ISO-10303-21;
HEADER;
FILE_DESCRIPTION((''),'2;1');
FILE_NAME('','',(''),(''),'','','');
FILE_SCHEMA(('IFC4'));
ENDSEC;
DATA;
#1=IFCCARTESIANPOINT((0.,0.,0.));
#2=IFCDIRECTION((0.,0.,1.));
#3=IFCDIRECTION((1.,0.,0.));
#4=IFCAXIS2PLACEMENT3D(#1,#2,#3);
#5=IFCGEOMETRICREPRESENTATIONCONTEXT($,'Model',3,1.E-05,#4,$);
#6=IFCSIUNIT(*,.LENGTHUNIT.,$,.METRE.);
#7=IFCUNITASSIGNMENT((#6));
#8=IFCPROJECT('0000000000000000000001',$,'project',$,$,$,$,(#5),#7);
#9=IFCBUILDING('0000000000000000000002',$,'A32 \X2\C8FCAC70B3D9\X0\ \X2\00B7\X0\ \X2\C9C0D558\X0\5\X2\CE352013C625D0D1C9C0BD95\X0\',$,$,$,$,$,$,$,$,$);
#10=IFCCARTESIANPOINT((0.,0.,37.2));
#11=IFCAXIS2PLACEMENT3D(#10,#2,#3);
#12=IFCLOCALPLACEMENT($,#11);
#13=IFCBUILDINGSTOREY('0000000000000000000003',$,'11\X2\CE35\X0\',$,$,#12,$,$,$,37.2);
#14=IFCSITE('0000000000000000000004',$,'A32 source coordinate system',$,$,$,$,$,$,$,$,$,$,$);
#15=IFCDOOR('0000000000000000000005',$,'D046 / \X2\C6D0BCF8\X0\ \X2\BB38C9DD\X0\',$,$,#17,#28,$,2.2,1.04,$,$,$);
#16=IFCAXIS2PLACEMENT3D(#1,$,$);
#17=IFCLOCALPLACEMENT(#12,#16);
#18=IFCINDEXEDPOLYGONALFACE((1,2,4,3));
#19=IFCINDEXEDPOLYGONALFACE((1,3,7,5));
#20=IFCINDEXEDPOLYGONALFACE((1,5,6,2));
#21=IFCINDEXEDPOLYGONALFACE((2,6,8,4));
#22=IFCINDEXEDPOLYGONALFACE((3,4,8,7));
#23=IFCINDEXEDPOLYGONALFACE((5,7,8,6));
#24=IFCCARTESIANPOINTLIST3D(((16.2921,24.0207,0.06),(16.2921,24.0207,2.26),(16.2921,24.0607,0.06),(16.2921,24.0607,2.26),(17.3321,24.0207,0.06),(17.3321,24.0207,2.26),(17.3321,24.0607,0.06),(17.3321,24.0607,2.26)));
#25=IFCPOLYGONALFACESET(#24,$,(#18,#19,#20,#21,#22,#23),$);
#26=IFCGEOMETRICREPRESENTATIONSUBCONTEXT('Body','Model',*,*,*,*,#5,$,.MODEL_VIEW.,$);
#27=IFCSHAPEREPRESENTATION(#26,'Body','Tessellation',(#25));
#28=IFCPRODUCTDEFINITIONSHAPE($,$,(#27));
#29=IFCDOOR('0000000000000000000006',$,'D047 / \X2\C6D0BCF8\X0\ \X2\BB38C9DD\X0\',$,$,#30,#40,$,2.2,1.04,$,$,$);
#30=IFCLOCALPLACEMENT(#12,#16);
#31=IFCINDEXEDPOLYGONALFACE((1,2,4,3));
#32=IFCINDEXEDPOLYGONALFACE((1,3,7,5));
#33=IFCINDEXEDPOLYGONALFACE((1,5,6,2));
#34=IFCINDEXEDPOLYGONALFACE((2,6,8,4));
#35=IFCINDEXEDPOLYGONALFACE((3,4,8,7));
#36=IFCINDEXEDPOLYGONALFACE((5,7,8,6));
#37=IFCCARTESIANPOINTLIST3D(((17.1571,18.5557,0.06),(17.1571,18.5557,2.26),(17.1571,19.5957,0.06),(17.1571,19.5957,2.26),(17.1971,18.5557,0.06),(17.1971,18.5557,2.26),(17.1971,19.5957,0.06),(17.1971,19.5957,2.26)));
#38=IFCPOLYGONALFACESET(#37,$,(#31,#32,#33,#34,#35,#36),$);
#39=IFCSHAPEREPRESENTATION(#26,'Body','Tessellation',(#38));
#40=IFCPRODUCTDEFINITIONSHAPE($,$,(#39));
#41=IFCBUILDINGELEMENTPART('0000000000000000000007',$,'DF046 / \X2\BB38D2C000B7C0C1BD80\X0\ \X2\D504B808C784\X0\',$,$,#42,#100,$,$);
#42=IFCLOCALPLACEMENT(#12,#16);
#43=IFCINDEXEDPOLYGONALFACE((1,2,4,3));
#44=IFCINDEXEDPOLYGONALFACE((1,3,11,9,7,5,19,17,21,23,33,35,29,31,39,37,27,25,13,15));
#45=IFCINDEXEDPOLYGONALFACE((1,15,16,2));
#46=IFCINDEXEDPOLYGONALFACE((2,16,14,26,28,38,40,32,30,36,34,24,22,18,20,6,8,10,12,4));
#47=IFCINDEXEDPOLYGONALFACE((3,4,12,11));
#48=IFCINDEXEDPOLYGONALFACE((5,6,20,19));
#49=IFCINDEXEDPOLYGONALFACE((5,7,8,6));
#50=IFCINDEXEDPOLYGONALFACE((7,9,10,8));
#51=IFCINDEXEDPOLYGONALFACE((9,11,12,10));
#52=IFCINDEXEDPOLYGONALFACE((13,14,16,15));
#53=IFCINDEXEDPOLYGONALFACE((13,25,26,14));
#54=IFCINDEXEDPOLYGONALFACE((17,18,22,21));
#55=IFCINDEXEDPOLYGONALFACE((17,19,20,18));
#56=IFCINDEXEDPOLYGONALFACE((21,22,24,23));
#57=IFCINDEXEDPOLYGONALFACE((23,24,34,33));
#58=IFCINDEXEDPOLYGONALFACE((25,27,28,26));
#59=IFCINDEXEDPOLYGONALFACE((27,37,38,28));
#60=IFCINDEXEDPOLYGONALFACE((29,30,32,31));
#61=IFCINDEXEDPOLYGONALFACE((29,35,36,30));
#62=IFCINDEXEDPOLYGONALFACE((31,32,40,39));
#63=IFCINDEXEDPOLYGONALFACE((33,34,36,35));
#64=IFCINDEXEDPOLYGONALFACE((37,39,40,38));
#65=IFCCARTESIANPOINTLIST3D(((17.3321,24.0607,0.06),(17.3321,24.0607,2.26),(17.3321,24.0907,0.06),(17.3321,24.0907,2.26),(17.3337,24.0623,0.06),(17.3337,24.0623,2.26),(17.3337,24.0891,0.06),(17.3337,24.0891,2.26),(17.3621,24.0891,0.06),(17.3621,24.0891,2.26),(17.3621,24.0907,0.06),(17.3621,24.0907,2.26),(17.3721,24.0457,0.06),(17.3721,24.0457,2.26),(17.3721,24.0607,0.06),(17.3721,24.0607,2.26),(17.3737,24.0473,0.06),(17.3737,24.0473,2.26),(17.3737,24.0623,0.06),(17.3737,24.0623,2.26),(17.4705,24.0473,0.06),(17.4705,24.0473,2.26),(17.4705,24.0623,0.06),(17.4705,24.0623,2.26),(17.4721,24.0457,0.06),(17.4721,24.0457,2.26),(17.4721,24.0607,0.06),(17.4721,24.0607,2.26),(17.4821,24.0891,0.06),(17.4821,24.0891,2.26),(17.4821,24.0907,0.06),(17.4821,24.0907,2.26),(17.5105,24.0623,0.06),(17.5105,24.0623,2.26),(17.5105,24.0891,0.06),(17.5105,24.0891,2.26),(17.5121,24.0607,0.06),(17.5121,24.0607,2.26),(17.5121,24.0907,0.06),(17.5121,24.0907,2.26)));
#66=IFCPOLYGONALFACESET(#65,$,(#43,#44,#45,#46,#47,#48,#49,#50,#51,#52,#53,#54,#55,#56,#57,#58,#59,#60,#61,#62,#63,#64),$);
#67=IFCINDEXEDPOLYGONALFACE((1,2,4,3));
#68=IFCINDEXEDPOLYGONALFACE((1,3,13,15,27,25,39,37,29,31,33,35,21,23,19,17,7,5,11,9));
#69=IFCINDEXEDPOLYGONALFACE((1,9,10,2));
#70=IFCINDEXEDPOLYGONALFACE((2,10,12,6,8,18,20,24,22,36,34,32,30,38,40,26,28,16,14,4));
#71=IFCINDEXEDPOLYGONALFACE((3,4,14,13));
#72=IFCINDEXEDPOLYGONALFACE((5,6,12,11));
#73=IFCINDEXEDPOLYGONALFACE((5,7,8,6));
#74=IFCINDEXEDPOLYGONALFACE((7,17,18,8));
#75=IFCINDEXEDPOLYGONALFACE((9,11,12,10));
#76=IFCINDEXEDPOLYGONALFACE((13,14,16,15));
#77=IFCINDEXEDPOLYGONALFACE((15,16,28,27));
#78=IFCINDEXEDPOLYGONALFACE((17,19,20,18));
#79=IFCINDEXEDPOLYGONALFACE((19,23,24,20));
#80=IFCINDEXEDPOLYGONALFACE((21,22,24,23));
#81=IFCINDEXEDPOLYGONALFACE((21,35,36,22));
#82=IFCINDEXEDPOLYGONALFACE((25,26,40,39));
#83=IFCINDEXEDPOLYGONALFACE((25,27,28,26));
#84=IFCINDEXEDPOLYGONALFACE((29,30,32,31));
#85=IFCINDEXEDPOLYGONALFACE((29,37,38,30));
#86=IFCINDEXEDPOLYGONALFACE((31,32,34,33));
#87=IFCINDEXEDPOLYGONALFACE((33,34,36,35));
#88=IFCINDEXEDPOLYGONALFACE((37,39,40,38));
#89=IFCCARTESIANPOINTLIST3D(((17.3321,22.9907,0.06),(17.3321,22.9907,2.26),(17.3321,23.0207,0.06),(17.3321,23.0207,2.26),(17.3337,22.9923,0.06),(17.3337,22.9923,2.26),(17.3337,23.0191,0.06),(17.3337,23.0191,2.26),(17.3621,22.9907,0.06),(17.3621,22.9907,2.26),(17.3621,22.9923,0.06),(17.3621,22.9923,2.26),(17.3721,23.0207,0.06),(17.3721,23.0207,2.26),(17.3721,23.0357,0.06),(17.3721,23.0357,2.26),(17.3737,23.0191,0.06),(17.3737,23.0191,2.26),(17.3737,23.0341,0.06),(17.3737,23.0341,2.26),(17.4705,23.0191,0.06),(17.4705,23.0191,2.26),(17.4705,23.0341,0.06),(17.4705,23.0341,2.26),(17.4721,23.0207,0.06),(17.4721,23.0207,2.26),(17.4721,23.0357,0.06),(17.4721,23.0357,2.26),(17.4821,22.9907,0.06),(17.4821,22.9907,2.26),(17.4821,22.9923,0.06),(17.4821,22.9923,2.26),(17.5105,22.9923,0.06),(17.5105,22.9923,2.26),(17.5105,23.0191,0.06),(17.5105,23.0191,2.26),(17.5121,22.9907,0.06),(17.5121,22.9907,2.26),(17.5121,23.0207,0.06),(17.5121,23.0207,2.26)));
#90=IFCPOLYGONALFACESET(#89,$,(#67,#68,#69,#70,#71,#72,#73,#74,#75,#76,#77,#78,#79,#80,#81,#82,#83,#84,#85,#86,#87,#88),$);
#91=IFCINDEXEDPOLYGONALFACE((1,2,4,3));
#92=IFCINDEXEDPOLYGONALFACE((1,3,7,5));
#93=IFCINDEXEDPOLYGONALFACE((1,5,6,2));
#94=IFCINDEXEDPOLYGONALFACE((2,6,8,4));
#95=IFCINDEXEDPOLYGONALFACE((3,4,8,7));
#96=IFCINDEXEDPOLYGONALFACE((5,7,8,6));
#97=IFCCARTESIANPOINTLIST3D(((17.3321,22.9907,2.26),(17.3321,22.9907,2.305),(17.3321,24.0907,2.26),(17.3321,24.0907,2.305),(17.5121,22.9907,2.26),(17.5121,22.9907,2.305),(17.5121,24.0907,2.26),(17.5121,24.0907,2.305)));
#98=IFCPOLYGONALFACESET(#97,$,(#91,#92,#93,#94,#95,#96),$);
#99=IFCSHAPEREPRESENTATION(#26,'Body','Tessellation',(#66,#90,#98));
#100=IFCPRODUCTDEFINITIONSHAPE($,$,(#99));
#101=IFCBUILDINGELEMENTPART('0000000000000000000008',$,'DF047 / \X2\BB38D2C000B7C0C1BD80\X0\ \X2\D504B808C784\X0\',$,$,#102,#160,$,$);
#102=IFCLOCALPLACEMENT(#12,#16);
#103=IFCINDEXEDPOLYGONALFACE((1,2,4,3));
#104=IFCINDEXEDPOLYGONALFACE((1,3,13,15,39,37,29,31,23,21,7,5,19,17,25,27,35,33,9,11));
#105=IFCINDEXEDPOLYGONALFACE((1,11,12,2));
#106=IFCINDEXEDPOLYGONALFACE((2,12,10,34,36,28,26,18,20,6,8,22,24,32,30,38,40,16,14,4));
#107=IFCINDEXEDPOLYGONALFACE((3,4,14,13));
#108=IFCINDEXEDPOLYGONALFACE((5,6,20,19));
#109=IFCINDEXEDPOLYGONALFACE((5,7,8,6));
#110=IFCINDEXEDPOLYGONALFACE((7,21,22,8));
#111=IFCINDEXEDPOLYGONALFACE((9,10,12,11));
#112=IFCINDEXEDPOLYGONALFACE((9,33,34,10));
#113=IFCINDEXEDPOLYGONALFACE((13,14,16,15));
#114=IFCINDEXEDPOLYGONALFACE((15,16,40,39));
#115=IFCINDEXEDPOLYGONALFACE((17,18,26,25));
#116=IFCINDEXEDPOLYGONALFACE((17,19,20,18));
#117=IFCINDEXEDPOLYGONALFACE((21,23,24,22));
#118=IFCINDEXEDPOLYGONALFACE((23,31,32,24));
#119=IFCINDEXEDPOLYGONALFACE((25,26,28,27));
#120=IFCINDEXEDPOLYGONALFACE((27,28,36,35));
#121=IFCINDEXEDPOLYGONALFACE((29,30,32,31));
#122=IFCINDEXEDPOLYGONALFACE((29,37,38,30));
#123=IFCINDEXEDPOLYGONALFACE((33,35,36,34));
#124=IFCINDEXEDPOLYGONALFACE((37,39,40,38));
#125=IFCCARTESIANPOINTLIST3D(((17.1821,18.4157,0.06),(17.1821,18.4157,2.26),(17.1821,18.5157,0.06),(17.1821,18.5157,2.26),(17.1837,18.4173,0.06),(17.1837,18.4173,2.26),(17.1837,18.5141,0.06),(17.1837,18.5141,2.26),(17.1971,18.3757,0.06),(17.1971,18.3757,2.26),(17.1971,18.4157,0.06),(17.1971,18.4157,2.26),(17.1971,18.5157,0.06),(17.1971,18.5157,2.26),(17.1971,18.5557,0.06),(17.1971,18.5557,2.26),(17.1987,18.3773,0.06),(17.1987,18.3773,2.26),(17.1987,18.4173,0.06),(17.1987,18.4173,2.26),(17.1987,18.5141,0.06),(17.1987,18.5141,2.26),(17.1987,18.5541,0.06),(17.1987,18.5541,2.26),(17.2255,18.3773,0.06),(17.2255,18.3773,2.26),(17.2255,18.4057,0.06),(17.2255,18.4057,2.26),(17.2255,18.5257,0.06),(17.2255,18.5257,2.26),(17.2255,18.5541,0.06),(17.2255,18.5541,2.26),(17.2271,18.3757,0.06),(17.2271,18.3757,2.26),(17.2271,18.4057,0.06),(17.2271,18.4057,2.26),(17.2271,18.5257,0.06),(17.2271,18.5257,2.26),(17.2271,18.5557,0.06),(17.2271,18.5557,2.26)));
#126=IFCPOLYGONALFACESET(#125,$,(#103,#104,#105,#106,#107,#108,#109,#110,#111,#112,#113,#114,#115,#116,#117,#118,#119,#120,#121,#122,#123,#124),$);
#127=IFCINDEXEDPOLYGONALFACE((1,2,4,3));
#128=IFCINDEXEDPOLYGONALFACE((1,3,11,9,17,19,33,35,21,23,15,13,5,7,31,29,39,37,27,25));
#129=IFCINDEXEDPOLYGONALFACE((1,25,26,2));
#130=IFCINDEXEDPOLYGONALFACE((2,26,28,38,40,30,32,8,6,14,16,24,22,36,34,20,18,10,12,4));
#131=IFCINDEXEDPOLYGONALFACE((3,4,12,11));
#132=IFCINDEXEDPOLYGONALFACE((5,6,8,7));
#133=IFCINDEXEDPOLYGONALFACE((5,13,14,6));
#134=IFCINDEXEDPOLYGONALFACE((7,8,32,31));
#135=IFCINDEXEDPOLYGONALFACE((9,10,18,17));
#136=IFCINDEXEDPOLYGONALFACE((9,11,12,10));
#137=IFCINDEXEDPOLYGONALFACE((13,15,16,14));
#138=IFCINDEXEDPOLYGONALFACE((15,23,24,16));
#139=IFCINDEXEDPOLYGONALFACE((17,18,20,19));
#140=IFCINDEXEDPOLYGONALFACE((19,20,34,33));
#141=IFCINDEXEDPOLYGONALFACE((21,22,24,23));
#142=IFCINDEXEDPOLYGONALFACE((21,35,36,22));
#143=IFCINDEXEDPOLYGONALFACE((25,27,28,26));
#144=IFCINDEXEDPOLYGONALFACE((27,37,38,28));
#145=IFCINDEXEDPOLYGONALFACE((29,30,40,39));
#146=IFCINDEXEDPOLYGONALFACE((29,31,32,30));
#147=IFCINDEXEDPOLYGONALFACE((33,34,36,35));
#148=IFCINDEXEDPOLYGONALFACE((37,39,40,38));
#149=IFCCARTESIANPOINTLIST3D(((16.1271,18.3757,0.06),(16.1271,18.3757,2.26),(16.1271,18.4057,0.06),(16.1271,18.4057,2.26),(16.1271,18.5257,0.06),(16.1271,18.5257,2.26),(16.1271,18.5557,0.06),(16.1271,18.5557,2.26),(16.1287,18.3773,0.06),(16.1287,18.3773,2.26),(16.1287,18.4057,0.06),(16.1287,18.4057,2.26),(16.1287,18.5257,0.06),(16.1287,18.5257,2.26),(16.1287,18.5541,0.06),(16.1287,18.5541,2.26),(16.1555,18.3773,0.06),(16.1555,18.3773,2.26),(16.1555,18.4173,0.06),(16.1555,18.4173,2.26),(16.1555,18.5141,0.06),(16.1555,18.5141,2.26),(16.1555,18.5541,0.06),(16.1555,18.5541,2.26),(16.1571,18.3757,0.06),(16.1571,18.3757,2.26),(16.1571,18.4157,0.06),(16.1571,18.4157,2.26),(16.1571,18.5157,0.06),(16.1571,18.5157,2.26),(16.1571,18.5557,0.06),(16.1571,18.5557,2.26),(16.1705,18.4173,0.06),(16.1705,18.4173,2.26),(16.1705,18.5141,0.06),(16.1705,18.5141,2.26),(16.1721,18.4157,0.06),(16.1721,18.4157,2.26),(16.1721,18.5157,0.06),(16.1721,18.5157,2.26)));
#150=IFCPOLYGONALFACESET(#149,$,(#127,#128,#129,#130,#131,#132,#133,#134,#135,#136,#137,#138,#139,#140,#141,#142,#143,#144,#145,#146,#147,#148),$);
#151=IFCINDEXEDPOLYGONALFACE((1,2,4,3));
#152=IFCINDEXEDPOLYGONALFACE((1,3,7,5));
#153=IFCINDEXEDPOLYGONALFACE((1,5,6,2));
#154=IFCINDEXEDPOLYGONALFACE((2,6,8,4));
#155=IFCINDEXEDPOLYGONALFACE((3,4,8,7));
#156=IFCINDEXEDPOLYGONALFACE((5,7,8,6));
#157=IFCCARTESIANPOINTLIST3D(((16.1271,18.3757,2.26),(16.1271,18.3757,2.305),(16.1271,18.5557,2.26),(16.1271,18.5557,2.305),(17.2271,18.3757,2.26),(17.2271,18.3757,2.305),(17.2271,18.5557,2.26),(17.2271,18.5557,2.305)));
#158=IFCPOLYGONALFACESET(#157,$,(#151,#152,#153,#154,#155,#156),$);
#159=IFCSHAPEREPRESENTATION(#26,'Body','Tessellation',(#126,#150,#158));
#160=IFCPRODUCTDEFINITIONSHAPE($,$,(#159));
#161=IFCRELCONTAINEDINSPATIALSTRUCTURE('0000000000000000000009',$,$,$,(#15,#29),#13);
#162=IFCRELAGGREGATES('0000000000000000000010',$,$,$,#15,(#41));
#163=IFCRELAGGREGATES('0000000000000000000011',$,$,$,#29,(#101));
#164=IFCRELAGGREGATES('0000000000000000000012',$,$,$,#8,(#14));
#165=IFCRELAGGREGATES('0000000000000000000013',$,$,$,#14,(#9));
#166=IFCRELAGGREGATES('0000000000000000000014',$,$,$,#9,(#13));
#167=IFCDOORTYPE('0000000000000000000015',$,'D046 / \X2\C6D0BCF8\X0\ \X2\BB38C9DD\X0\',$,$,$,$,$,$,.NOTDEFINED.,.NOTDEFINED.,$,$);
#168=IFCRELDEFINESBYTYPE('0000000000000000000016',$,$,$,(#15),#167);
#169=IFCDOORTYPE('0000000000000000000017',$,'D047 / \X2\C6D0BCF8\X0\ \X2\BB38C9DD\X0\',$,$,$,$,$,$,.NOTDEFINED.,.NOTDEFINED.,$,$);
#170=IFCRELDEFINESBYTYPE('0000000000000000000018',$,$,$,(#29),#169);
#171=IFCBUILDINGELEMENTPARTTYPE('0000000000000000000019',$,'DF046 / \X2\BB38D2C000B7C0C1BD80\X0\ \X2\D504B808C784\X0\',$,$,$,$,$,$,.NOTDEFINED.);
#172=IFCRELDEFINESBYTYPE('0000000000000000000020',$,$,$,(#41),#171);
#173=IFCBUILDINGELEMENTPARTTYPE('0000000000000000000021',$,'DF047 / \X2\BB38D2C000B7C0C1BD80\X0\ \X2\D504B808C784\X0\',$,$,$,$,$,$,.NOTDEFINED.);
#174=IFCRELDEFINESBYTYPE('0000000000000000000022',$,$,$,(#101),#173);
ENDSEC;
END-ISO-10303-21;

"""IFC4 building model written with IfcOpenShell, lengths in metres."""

from ifc_helpers import new_model, si_unit, frame, origin, origin_with_axes, place, context, subcontext, project, spatial, polyline, outline, extrude, source, transform, mapped, type_object, type_shapes, element, aggregate, save


model = new_model("IFC4")

# Units and contexts
model_context = context("Model", 3, precision=1e-05, world=origin_with_axes())
body_context = subcontext(model_context, "Body", "Model", "MODEL_VIEW")
ifc_project = project(units=[si_unit("LENGTHUNIT", "METRE")], contexts=[model_context])

# Site, building, storey
storey_placement = place(None, frame((0.0, 0.0, 37.2), z_axis=(0.0, 0.0, 1.0), x_axis=(1.0, 0.0, 0.0)))
site = spatial("IfcSite", under=ifc_project, Name="A32 source coordinate system")
building = spatial("IfcBuilding", under=site, Name="A32 주거동 · 지하5층–옥탑지붕")
storey = spatial("IfcBuildingStorey", under=building, at=storey_placement, Name="11층", Elevation=37.2)

# Doors
door_type_1 = type_object("IfcDoorType", Name="D046 / 원본 문짝", OperationType="NOTDEFINED", PredefinedType="NOTDEFINED")
shared_shape_1 = source(origin(), body_context, "Body", "SweptSolid", [
    extrude(outline(polyline([(17.3321, 24.0607), (17.3321, 24.0207), (16.2921, 24.0207), (16.2921, 24.0607), (17.3321, 24.0607)])), frame((0.0, 0.0, 0.06)), (0.0, 0.0, 1.0), 2.2),
])
type_shapes(door_type_1, [shared_shape_1])
door_1_placement = place(storey_placement, origin_with_axes())
door_1 = element("IfcDoor", 1, at=door_1_placement, inside=storey, type_object=door_type_1, Name="D046 / 원본 문짝", OverallHeight=2.2, OverallWidth=1.04, context=body_context, shape_type="MappedRepresentation", body=[
    mapped(shared_shape_1, transform((0.0, 0.0, 0.0), scale=1.0)),
])
door_type_2 = type_object("IfcDoorType", Name="D047 / 원본 문짝", OperationType="NOTDEFINED", PredefinedType="NOTDEFINED")
shared_shape_2 = source(origin(), body_context, "Body", "SweptSolid", [
    extrude(outline(polyline([(17.1971, 18.5557), (17.1571, 18.5557), (17.1571, 19.5957), (17.1971, 19.5957), (17.1971, 18.5557)])), frame((0.0, 0.0, 0.06)), (0.0, 0.0, 1.0), 2.2),
])
type_shapes(door_type_2, [shared_shape_2])
door_2_placement = place(storey_placement, origin_with_axes())
door_2 = element("IfcDoor", 2, at=door_2_placement, inside=storey, type_object=door_type_2, Name="D047 / 원본 문짝", OverallHeight=2.2, OverallWidth=1.04, context=body_context, shape_type="MappedRepresentation", body=[
    mapped(shared_shape_2, transform((0.0, 0.0, 0.0), scale=1.0)),
])

# Building element parts
building_element_part_type_1 = type_object("IfcBuildingElementPartType", Name="DF046 / 문틀·상부 프레임", PredefinedType="NOTDEFINED")
shared_shape_3 = source(origin(), body_context, "Body", "SweptSolid", [
    extrude(outline(polyline([(17.3337, 24.0891), (17.3337, 24.0623), (17.3737, 24.0623), (17.3737, 24.0473), (17.4705, 24.0473), (17.4705, 24.0623), (17.5105, 24.0623), (17.5105, 24.0891), (17.4821, 24.0891), (17.4821, 24.0907), (17.5121, 24.0907), (17.5121, 24.0607), (17.4721, 24.0607), (17.4721, 24.0457), (17.3721, 24.0457), (17.3721, 24.0607), (17.3321, 24.0607), (17.3321, 24.0907), (17.3621, 24.0907), (17.3621, 24.0891), (17.3337, 24.0891)])), frame((0.0, 0.0, 0.06)), (0.0, 0.0, 1.0), 2.2),
    extrude(outline(polyline([(17.3621, 22.9907), (17.3321, 22.9907), (17.3321, 23.0207), (17.3721, 23.0207), (17.3721, 23.0357), (17.4721, 23.0357), (17.4721, 23.0207), (17.5121, 23.0207), (17.5121, 22.9907), (17.4821, 22.9907), (17.4821, 22.9923), (17.5105, 22.9923), (17.5105, 23.0191), (17.4705, 23.0191), (17.4705, 23.0341), (17.3737, 23.0341), (17.3737, 23.0191), (17.3337, 23.0191), (17.3337, 22.9923), (17.3621, 22.9923), (17.3621, 22.9907)])), frame((0.0, 0.0, 0.06)), (0.0, 0.0, 1.0), 2.2),
    extrude(outline(polyline([(17.3321, 22.9907), (17.3321, 24.0907), (17.5121, 24.0907), (17.5121, 22.9907), (17.3321, 22.9907)])), frame((0.0, 0.0, 2.26)), (0.0, 0.0, 1.0), 0.045),
])
type_shapes(building_element_part_type_1, [shared_shape_3])
building_element_part_1_placement = place(door_1_placement, origin_with_axes())
building_element_part_1 = element("IfcBuildingElementPart", 3, at=building_element_part_1_placement, type_object=building_element_part_type_1, Name="DF046 / 문틀·상부 프레임", context=body_context, shape_type="MappedRepresentation", body=[
    mapped(shared_shape_3, transform((0.0, 0.0, 0.0), scale=1.0)),
])
aggregate(door_1, [building_element_part_1])
building_element_part_type_2 = type_object("IfcBuildingElementPartType", Name="DF047 / 문틀·상부 프레임", PredefinedType="NOTDEFINED")
shared_shape_4 = source(origin(), body_context, "Body", "SweptSolid", [
    extrude(outline(polyline([(17.2255, 18.5541), (17.1987, 18.5541), (17.1987, 18.5141), (17.1837, 18.5141), (17.1837, 18.4173), (17.1987, 18.4173), (17.1987, 18.3773), (17.2255, 18.3773), (17.2255, 18.4057), (17.2271, 18.4057), (17.2271, 18.3757), (17.1971, 18.3757), (17.1971, 18.4157), (17.1821, 18.4157), (17.1821, 18.5157), (17.1971, 18.5157), (17.1971, 18.5557), (17.2271, 18.5557), (17.2271, 18.5257), (17.2255, 18.5257), (17.2255, 18.5541)])), frame((0.0, 0.0, 0.06)), (0.0, 0.0, 1.0), 2.2),
    extrude(outline(polyline([(16.1271, 18.5257), (16.1271, 18.5557), (16.1571, 18.5557), (16.1571, 18.5157), (16.1721, 18.5157), (16.1721, 18.4157), (16.1571, 18.4157), (16.1571, 18.3757), (16.1271, 18.3757), (16.1271, 18.4057), (16.1287, 18.4057), (16.1287, 18.3773), (16.1555, 18.3773), (16.1555, 18.4173), (16.1705, 18.4173), (16.1705, 18.5141), (16.1555, 18.5141), (16.1555, 18.5541), (16.1287, 18.5541), (16.1287, 18.5257), (16.1271, 18.5257)])), frame((0.0, 0.0, 0.06)), (0.0, 0.0, 1.0), 2.2),
    extrude(outline(polyline([(16.1271, 18.3757), (16.1271, 18.5557), (17.2271, 18.5557), (17.2271, 18.3757), (16.1271, 18.3757)])), frame((0.0, 0.0, 2.26)), (0.0, 0.0, 1.0), 0.045),
])
type_shapes(building_element_part_type_2, [shared_shape_4])
building_element_part_2_placement = place(door_2_placement, origin_with_axes())
building_element_part_2 = element("IfcBuildingElementPart", 4, at=building_element_part_2_placement, type_object=building_element_part_type_2, Name="DF047 / 문틀·상부 프레임", context=body_context, shape_type="MappedRepresentation", body=[
    mapped(shared_shape_4, transform((0.0, 0.0, 0.0), scale=1.0)),
])
aggregate(door_2, [building_element_part_2])

save(model, "model.ifc")
